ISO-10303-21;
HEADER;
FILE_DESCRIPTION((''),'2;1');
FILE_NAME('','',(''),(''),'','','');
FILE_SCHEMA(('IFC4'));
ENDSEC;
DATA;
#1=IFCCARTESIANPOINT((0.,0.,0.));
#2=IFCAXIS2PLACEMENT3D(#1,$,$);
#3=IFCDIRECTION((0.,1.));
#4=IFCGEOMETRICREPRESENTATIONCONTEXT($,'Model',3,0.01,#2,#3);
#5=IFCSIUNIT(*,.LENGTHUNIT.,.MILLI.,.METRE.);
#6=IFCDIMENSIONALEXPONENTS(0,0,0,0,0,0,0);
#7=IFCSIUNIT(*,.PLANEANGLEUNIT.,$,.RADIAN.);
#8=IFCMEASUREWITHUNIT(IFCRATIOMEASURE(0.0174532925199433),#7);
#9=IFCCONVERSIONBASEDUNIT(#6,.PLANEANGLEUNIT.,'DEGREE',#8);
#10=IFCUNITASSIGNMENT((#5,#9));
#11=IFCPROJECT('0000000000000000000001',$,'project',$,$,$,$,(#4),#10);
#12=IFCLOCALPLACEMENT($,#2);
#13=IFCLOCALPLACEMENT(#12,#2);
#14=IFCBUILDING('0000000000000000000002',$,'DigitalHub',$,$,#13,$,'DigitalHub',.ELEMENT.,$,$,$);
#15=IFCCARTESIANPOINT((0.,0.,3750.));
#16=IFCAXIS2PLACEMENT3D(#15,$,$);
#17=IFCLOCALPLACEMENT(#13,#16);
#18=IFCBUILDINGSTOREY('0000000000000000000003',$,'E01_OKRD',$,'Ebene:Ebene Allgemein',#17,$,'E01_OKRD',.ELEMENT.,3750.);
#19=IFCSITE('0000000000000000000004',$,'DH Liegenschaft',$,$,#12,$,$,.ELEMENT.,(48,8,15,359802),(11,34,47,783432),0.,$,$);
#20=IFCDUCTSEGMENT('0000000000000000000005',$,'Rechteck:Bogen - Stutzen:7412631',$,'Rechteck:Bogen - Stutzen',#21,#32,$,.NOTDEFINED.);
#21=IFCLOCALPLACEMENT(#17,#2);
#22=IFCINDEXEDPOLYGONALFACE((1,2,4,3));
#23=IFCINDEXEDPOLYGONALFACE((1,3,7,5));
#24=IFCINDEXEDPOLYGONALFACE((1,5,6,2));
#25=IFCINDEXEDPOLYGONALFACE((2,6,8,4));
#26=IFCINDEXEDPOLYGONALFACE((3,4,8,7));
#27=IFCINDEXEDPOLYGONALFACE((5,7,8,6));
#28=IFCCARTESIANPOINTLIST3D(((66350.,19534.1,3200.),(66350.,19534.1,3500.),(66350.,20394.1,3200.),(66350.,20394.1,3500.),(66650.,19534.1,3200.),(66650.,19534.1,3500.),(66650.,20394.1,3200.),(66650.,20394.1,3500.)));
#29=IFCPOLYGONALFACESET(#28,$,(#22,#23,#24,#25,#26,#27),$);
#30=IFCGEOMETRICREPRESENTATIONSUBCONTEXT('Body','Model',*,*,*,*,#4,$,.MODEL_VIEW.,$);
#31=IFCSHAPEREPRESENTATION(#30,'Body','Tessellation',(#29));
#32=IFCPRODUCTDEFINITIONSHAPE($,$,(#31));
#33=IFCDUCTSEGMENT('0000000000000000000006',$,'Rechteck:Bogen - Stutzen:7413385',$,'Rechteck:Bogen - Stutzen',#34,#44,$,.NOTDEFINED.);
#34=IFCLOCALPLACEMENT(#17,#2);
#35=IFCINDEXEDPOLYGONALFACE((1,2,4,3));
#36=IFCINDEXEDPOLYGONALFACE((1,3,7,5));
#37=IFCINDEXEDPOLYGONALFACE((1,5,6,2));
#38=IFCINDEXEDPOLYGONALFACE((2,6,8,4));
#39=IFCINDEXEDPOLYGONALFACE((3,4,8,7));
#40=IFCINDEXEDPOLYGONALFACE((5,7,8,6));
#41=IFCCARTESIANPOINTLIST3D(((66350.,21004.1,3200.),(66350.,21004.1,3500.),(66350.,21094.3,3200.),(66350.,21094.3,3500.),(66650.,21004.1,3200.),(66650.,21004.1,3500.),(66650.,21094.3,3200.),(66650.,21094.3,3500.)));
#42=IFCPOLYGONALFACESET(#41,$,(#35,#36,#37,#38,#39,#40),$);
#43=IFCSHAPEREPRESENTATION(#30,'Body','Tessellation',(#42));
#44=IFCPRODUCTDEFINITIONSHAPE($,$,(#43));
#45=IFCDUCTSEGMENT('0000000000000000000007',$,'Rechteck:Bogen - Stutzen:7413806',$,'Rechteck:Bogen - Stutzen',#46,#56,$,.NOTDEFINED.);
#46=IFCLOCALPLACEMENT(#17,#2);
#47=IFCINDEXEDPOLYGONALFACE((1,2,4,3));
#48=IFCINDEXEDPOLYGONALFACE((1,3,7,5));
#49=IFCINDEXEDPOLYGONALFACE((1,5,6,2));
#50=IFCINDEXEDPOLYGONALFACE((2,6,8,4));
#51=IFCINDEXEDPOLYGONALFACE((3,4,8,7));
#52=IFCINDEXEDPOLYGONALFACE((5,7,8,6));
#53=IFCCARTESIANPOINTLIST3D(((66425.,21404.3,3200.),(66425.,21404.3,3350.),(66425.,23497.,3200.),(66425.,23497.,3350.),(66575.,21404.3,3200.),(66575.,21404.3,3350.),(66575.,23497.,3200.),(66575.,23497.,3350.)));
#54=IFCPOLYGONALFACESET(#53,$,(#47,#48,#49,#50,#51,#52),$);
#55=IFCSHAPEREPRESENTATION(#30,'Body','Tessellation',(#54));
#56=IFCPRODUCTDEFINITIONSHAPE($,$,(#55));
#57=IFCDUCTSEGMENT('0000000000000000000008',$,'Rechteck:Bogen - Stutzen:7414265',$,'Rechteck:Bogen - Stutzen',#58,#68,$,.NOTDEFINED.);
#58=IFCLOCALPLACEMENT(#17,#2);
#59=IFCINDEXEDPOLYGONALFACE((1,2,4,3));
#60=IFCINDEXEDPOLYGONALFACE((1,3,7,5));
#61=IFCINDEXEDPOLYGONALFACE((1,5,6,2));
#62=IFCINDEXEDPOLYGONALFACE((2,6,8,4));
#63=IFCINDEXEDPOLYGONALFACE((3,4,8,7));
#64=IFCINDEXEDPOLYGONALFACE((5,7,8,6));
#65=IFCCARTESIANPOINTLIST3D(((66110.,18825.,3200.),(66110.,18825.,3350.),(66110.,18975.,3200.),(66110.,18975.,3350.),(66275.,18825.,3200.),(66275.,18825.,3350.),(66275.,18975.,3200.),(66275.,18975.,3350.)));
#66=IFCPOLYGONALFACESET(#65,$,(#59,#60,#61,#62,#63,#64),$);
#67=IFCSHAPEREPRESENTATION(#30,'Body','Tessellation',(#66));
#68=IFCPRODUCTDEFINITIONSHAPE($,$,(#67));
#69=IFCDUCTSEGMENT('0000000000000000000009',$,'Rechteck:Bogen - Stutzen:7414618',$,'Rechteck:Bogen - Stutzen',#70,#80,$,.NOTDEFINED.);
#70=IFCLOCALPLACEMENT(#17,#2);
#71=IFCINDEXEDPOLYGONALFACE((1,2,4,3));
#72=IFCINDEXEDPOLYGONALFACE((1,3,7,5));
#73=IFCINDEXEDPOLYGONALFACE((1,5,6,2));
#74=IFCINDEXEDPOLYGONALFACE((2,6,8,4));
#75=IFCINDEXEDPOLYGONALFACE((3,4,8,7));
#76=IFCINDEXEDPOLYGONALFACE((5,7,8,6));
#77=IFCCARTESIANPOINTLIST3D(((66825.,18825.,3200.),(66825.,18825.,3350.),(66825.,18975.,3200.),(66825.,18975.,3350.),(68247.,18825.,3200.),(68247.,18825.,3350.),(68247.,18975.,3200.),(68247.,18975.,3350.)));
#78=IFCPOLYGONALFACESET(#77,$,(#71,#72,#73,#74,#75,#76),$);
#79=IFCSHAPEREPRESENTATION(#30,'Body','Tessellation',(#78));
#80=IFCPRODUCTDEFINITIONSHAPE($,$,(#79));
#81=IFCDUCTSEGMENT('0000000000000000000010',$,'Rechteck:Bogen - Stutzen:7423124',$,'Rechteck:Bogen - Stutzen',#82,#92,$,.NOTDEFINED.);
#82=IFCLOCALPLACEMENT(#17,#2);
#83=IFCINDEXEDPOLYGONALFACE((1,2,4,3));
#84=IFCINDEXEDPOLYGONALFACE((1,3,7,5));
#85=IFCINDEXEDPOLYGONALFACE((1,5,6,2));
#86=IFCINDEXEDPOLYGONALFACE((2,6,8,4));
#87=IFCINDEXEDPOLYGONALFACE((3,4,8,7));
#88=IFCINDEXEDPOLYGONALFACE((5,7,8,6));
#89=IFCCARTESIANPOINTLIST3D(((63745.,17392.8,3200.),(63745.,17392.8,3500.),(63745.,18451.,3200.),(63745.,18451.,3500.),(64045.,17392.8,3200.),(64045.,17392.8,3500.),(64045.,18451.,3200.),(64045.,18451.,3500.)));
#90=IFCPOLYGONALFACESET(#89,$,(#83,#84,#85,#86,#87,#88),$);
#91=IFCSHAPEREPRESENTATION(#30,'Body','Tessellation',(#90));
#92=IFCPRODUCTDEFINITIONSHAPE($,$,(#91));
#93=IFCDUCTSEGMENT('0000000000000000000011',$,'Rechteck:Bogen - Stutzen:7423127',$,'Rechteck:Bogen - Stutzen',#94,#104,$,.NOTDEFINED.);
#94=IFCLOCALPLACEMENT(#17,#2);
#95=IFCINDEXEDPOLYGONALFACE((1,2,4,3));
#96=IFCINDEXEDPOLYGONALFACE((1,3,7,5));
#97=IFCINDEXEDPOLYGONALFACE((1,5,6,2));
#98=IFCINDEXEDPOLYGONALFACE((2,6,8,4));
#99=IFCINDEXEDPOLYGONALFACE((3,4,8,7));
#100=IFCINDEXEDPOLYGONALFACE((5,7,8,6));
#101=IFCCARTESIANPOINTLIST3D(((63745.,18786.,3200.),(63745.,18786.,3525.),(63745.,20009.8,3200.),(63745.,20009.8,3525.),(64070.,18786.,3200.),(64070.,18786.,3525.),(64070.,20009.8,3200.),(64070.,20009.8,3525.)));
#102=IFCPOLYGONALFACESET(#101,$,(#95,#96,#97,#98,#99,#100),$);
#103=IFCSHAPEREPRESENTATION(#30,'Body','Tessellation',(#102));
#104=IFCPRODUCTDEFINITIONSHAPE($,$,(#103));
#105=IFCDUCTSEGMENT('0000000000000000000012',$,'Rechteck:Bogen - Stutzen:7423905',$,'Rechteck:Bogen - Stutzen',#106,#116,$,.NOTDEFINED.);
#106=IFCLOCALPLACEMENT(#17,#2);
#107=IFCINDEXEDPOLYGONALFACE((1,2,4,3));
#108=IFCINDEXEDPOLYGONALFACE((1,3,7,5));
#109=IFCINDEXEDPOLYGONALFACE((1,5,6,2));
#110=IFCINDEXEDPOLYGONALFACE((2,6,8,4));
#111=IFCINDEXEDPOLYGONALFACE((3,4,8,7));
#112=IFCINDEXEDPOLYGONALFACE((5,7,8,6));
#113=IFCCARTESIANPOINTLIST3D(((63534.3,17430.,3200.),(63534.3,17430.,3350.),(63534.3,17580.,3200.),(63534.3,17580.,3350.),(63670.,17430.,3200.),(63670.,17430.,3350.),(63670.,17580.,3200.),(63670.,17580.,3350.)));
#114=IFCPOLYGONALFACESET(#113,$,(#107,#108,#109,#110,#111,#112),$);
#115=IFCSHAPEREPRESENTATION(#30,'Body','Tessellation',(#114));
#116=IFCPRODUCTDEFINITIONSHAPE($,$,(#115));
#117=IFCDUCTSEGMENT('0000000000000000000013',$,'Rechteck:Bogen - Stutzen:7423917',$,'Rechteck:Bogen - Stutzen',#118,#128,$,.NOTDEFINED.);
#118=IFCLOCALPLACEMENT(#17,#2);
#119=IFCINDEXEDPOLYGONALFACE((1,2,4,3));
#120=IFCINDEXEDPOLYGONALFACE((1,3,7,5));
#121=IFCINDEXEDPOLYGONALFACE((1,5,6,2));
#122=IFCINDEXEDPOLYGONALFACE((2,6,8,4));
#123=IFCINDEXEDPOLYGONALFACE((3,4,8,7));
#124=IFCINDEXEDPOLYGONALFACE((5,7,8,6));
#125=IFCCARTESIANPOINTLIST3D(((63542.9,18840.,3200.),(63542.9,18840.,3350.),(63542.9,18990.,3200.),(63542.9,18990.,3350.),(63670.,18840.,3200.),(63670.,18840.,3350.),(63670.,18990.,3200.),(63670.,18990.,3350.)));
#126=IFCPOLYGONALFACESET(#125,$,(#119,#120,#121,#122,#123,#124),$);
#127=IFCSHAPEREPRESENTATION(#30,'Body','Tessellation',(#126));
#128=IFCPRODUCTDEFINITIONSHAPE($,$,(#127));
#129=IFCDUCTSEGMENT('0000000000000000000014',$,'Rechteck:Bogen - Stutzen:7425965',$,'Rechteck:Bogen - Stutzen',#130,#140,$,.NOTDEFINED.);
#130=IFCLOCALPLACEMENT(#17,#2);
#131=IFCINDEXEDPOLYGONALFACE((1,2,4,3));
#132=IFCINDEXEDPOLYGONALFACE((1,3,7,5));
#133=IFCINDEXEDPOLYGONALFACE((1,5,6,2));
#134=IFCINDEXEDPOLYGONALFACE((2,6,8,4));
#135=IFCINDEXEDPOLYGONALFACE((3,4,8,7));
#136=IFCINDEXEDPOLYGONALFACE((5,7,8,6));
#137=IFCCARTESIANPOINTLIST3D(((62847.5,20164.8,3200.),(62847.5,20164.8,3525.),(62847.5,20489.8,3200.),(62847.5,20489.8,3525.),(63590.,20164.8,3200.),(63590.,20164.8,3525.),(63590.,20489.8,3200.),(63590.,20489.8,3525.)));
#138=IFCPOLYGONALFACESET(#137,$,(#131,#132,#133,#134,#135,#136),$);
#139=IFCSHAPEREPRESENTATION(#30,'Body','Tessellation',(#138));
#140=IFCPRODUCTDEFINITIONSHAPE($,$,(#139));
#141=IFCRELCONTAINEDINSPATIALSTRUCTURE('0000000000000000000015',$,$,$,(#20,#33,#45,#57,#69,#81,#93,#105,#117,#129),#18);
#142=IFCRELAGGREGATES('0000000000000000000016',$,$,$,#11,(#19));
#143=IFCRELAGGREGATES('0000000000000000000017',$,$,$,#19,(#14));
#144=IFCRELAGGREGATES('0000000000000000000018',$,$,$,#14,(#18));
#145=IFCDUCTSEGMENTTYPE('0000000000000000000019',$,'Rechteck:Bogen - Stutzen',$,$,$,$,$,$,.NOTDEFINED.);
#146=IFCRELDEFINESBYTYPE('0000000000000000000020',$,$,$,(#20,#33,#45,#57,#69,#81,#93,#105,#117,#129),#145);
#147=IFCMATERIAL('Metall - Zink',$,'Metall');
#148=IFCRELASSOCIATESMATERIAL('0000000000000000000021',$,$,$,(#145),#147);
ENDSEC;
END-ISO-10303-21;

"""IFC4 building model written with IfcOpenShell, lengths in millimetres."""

from ifc_helpers import new_model, entity, si_unit, converted_unit, direction, frame, origin, place, context, subcontext, project, spatial, indexed_curve, outline, extrude, material, type_object, element, save


model = new_model("IFC4")

# Units and contexts
model_context = context("Model", 3, precision=0.01, world=origin(), true_north=direction((0.0, 1.0)))
body_context = subcontext(model_context, "Body", "Model", "MODEL_VIEW")
ifc_project = project(units=[si_unit("LENGTHUNIT", "METRE", prefix="MILLI"), converted_unit("PLANEANGLEUNIT", "DEGREE", entity("IfcRatioMeasure", 0.0174532925199433), si_unit("PLANEANGLEUNIT", "RADIAN"), dimensions=[0, 0, 0, 0, 0, 0, 0])], contexts=[model_context])

# Site, building, storey
site_placement = place(None, origin())
site = spatial("IfcSite", under=ifc_project, at=site_placement, Name="DH Liegenschaft", CompositionType="ELEMENT", RefLatitude=(48, 8, 15, 359802), RefLongitude=(11, 34, 47, 783432), RefElevation=0.0)
building_placement = place(site_placement, origin())
building = spatial("IfcBuilding", under=site, at=building_placement, Name="DigitalHub", LongName="DigitalHub", CompositionType="ELEMENT")
storey_placement = place(building_placement, frame((0.0, 0.0, 3750.0)))
storey = spatial("IfcBuildingStorey", under=building, at=storey_placement, Name="E01_OKRD", ObjectType="Ebene:Ebene Allgemein", LongName="E01_OKRD", CompositionType="ELEMENT", Elevation=3750.0)

# Duct segments
ifc_material_1 = material(Name="Metall - Zink", Category="Metall")
duct_segment_type_1 = type_object("IfcDuctSegmentType", Name="Rechteck:Bogen - Stutzen", PredefinedType="NOTDEFINED", material=ifc_material_1)
duct_segment_1_placement = place(storey_placement, frame((66350.0, 19534.1, 3200.0)))
element("IfcDuctSegment", 1, at=duct_segment_1_placement, inside=storey, type_object=duct_segment_type_1, Name="Rechteck:Bogen - Stutzen:7412631", ObjectType="Rechteck:Bogen - Stutzen", PredefinedType="NOTDEFINED", context=body_context, shape_type="SweptSolid", body=[
    extrude(outline(indexed_curve([(-430.0, -150.0), (430.0, -150.0), (430.0, 150.0), (-430.0, 150.0), (-430.0, -150.0)], self_intersect=False)), frame((150.0, 430.0, 0.0), z_axis=(0.0, 0.0, 1.0), x_axis=(0.0, -1.0, 0.0)), (0.0, 0.0, 1.0), 300.0),
])
duct_segment_2_placement = place(storey_placement, frame((66350.0, 21004.1, 3200.0)))
element("IfcDuctSegment", 2, at=duct_segment_2_placement, inside=storey, type_object=duct_segment_type_1, Name="Rechteck:Bogen - Stutzen:7413385", ObjectType="Rechteck:Bogen - Stutzen", PredefinedType="NOTDEFINED", context=body_context, shape_type="SweptSolid", body=[
    extrude(outline(indexed_curve([(-45.1, -150.0), (45.1, -150.0), (45.1, 150.0), (-45.1, 150.0), (-45.1, -150.0)], self_intersect=False)), frame((150.0, 45.1, 0.0), z_axis=(0.0, 0.0, 1.0), x_axis=(0.0, 1.0, 0.0)), (0.0, 0.0, 1.0), 300.0),
])
duct_segment_3_placement = place(storey_placement, frame((66425.0, 21404.3, 3200.0)))
element("IfcDuctSegment", 3, at=duct_segment_3_placement, inside=storey, type_object=duct_segment_type_1, Name="Rechteck:Bogen - Stutzen:7413806", ObjectType="Rechteck:Bogen - Stutzen", PredefinedType="NOTDEFINED", context=body_context, shape_type="SweptSolid", body=[
    extrude(outline(indexed_curve([(-1046.4, -75.0), (1046.4, -75.0), (1046.4, 75.0), (-1046.4, 75.0), (-1046.4, -75.0)], self_intersect=False)), frame((75.0, 1046.4, 0.0), z_axis=(0.0, 0.0, 1.0), x_axis=(0.0, -1.0, 0.0)), (0.0, 0.0, 1.0), 150.0),
])
duct_segment_4_placement = place(storey_placement, frame((66110.0, 18825.0, 3200.0)))
element("IfcDuctSegment", 4, at=duct_segment_4_placement, inside=storey, type_object=duct_segment_type_1, Name="Rechteck:Bogen - Stutzen:7414265", ObjectType="Rechteck:Bogen - Stutzen", PredefinedType="NOTDEFINED", context=body_context, shape_type="SweptSolid", body=[
    extrude(outline(indexed_curve([(-82.5, -75.0), (82.5, -75.0), (82.5, 75.0), (-82.5, 75.0), (-82.5, -75.0)], self_intersect=False)), frame((82.5, 75.0, 0.0), z_axis=(0.0, 0.0, 1.0), x_axis=(-1.0, 0.0, 0.0)), (0.0, 0.0, 1.0), 150.0),
])
duct_segment_5_placement = place(storey_placement, frame((66825.0, 18825.0, 3200.0)))
element("IfcDuctSegment", 5, at=duct_segment_5_placement, inside=storey, type_object=duct_segment_type_1, Name="Rechteck:Bogen - Stutzen:7414618", ObjectType="Rechteck:Bogen - Stutzen", PredefinedType="NOTDEFINED", context=body_context, shape_type="SweptSolid", body=[
    extrude(outline(indexed_curve([(-711.0, -75.0), (711.0, -75.0), (711.0, 75.0), (-711.0, 75.0), (-711.0, -75.0)], self_intersect=False)), frame((711.0, 75.0, 0.0), z_axis=(-0.000013, 0.0, 1.0), x_axis=(-1.0, 0.0, -0.000013)), (0.0, 0.0, 1.0), 150.0),
])
duct_segment_6_placement = place(storey_placement, frame((63745.0, 17392.8, 3200.0)))
element("IfcDuctSegment", 6, at=duct_segment_6_placement, inside=storey, type_object=duct_segment_type_1, Name="Rechteck:Bogen - Stutzen:7423124", ObjectType="Rechteck:Bogen - Stutzen", PredefinedType="NOTDEFINED", context=body_context, shape_type="SweptSolid", body=[
    extrude(outline(indexed_curve([(-529.1, -150.0), (529.1, -150.0), (529.1, 150.0), (-529.1, 150.0), (-529.1, -150.0)], self_intersect=False)), frame((150.0, 529.1, 0.0), z_axis=(0.0, 0.0, 1.0), x_axis=(0.0, -1.0, 0.0)), (0.0, 0.0, 1.0), 300.0),
])
duct_segment_7_placement = place(storey_placement, frame((63745.0, 18786.0, 3200.0)))
element("IfcDuctSegment", 7, at=duct_segment_7_placement, inside=storey, type_object=duct_segment_type_1, Name="Rechteck:Bogen - Stutzen:7423127", ObjectType="Rechteck:Bogen - Stutzen", PredefinedType="NOTDEFINED", context=body_context, shape_type="SweptSolid", body=[
    extrude(outline(indexed_curve([(-611.9, -162.5), (611.9, -162.5), (611.9, 162.5), (-611.9, 162.5), (-611.9, -162.5)], self_intersect=False)), frame((162.5, 611.9, 0.0), z_axis=(0.0, 0.0, 1.0), x_axis=(0.0, 1.0, 0.0)), (0.0, 0.0, 1.0), 325.0),
])
duct_segment_8_placement = place(storey_placement, frame((63534.3, 17430.0, 3200.0)))
element("IfcDuctSegment", 8, at=duct_segment_8_placement, inside=storey, type_object=duct_segment_type_1, Name="Rechteck:Bogen - Stutzen:7423905", ObjectType="Rechteck:Bogen - Stutzen", PredefinedType="NOTDEFINED", context=body_context, shape_type="SweptSolid", body=[
    extrude(outline(indexed_curve([(-67.8, -75.0), (67.8, -75.0), (67.8, 75.0), (-67.8, 75.0), (-67.8, -75.0)], self_intersect=False)), frame((67.8, 75.0, 0.0)), (0.0, 0.0, 1.0), 150.0),
])
duct_segment_9_placement = place(storey_placement, frame((63542.9, 18840.0, 3200.0)))
element("IfcDuctSegment", 9, at=duct_segment_9_placement, inside=storey, type_object=duct_segment_type_1, Name="Rechteck:Bogen - Stutzen:7423917", ObjectType="Rechteck:Bogen - Stutzen", PredefinedType="NOTDEFINED", context=body_context, shape_type="SweptSolid", body=[
    extrude(outline(indexed_curve([(-63.5, -75.0), (63.5, -75.0), (63.5, 75.0), (-63.5, 75.0), (-63.5, -75.0)], self_intersect=False)), frame((63.5, 75.0, 0.0)), (0.0, 0.0, 1.0), 150.0),
])
duct_segment_10_placement = place(storey_placement, frame((62847.5, 20164.8, 3200.0)))
element("IfcDuctSegment", 10, at=duct_segment_10_placement, inside=storey, type_object=duct_segment_type_1, Name="Rechteck:Bogen - Stutzen:7425965", ObjectType="Rechteck:Bogen - Stutzen", PredefinedType="NOTDEFINED", context=body_context, shape_type="SweptSolid", body=[
    extrude(outline(indexed_curve([(-371.2, -162.5), (371.3, -162.5), (371.3, 162.5), (-371.2, 162.5), (-371.2, -162.5)], self_intersect=False)), frame((371.3, 162.5, 0.0), z_axis=(0.0, 0.0, 1.0), x_axis=(-1.0, 0.0, 0.0)), (0.0, 0.0, 1.0), 325.0),
])

save(model, "model.ifc")
